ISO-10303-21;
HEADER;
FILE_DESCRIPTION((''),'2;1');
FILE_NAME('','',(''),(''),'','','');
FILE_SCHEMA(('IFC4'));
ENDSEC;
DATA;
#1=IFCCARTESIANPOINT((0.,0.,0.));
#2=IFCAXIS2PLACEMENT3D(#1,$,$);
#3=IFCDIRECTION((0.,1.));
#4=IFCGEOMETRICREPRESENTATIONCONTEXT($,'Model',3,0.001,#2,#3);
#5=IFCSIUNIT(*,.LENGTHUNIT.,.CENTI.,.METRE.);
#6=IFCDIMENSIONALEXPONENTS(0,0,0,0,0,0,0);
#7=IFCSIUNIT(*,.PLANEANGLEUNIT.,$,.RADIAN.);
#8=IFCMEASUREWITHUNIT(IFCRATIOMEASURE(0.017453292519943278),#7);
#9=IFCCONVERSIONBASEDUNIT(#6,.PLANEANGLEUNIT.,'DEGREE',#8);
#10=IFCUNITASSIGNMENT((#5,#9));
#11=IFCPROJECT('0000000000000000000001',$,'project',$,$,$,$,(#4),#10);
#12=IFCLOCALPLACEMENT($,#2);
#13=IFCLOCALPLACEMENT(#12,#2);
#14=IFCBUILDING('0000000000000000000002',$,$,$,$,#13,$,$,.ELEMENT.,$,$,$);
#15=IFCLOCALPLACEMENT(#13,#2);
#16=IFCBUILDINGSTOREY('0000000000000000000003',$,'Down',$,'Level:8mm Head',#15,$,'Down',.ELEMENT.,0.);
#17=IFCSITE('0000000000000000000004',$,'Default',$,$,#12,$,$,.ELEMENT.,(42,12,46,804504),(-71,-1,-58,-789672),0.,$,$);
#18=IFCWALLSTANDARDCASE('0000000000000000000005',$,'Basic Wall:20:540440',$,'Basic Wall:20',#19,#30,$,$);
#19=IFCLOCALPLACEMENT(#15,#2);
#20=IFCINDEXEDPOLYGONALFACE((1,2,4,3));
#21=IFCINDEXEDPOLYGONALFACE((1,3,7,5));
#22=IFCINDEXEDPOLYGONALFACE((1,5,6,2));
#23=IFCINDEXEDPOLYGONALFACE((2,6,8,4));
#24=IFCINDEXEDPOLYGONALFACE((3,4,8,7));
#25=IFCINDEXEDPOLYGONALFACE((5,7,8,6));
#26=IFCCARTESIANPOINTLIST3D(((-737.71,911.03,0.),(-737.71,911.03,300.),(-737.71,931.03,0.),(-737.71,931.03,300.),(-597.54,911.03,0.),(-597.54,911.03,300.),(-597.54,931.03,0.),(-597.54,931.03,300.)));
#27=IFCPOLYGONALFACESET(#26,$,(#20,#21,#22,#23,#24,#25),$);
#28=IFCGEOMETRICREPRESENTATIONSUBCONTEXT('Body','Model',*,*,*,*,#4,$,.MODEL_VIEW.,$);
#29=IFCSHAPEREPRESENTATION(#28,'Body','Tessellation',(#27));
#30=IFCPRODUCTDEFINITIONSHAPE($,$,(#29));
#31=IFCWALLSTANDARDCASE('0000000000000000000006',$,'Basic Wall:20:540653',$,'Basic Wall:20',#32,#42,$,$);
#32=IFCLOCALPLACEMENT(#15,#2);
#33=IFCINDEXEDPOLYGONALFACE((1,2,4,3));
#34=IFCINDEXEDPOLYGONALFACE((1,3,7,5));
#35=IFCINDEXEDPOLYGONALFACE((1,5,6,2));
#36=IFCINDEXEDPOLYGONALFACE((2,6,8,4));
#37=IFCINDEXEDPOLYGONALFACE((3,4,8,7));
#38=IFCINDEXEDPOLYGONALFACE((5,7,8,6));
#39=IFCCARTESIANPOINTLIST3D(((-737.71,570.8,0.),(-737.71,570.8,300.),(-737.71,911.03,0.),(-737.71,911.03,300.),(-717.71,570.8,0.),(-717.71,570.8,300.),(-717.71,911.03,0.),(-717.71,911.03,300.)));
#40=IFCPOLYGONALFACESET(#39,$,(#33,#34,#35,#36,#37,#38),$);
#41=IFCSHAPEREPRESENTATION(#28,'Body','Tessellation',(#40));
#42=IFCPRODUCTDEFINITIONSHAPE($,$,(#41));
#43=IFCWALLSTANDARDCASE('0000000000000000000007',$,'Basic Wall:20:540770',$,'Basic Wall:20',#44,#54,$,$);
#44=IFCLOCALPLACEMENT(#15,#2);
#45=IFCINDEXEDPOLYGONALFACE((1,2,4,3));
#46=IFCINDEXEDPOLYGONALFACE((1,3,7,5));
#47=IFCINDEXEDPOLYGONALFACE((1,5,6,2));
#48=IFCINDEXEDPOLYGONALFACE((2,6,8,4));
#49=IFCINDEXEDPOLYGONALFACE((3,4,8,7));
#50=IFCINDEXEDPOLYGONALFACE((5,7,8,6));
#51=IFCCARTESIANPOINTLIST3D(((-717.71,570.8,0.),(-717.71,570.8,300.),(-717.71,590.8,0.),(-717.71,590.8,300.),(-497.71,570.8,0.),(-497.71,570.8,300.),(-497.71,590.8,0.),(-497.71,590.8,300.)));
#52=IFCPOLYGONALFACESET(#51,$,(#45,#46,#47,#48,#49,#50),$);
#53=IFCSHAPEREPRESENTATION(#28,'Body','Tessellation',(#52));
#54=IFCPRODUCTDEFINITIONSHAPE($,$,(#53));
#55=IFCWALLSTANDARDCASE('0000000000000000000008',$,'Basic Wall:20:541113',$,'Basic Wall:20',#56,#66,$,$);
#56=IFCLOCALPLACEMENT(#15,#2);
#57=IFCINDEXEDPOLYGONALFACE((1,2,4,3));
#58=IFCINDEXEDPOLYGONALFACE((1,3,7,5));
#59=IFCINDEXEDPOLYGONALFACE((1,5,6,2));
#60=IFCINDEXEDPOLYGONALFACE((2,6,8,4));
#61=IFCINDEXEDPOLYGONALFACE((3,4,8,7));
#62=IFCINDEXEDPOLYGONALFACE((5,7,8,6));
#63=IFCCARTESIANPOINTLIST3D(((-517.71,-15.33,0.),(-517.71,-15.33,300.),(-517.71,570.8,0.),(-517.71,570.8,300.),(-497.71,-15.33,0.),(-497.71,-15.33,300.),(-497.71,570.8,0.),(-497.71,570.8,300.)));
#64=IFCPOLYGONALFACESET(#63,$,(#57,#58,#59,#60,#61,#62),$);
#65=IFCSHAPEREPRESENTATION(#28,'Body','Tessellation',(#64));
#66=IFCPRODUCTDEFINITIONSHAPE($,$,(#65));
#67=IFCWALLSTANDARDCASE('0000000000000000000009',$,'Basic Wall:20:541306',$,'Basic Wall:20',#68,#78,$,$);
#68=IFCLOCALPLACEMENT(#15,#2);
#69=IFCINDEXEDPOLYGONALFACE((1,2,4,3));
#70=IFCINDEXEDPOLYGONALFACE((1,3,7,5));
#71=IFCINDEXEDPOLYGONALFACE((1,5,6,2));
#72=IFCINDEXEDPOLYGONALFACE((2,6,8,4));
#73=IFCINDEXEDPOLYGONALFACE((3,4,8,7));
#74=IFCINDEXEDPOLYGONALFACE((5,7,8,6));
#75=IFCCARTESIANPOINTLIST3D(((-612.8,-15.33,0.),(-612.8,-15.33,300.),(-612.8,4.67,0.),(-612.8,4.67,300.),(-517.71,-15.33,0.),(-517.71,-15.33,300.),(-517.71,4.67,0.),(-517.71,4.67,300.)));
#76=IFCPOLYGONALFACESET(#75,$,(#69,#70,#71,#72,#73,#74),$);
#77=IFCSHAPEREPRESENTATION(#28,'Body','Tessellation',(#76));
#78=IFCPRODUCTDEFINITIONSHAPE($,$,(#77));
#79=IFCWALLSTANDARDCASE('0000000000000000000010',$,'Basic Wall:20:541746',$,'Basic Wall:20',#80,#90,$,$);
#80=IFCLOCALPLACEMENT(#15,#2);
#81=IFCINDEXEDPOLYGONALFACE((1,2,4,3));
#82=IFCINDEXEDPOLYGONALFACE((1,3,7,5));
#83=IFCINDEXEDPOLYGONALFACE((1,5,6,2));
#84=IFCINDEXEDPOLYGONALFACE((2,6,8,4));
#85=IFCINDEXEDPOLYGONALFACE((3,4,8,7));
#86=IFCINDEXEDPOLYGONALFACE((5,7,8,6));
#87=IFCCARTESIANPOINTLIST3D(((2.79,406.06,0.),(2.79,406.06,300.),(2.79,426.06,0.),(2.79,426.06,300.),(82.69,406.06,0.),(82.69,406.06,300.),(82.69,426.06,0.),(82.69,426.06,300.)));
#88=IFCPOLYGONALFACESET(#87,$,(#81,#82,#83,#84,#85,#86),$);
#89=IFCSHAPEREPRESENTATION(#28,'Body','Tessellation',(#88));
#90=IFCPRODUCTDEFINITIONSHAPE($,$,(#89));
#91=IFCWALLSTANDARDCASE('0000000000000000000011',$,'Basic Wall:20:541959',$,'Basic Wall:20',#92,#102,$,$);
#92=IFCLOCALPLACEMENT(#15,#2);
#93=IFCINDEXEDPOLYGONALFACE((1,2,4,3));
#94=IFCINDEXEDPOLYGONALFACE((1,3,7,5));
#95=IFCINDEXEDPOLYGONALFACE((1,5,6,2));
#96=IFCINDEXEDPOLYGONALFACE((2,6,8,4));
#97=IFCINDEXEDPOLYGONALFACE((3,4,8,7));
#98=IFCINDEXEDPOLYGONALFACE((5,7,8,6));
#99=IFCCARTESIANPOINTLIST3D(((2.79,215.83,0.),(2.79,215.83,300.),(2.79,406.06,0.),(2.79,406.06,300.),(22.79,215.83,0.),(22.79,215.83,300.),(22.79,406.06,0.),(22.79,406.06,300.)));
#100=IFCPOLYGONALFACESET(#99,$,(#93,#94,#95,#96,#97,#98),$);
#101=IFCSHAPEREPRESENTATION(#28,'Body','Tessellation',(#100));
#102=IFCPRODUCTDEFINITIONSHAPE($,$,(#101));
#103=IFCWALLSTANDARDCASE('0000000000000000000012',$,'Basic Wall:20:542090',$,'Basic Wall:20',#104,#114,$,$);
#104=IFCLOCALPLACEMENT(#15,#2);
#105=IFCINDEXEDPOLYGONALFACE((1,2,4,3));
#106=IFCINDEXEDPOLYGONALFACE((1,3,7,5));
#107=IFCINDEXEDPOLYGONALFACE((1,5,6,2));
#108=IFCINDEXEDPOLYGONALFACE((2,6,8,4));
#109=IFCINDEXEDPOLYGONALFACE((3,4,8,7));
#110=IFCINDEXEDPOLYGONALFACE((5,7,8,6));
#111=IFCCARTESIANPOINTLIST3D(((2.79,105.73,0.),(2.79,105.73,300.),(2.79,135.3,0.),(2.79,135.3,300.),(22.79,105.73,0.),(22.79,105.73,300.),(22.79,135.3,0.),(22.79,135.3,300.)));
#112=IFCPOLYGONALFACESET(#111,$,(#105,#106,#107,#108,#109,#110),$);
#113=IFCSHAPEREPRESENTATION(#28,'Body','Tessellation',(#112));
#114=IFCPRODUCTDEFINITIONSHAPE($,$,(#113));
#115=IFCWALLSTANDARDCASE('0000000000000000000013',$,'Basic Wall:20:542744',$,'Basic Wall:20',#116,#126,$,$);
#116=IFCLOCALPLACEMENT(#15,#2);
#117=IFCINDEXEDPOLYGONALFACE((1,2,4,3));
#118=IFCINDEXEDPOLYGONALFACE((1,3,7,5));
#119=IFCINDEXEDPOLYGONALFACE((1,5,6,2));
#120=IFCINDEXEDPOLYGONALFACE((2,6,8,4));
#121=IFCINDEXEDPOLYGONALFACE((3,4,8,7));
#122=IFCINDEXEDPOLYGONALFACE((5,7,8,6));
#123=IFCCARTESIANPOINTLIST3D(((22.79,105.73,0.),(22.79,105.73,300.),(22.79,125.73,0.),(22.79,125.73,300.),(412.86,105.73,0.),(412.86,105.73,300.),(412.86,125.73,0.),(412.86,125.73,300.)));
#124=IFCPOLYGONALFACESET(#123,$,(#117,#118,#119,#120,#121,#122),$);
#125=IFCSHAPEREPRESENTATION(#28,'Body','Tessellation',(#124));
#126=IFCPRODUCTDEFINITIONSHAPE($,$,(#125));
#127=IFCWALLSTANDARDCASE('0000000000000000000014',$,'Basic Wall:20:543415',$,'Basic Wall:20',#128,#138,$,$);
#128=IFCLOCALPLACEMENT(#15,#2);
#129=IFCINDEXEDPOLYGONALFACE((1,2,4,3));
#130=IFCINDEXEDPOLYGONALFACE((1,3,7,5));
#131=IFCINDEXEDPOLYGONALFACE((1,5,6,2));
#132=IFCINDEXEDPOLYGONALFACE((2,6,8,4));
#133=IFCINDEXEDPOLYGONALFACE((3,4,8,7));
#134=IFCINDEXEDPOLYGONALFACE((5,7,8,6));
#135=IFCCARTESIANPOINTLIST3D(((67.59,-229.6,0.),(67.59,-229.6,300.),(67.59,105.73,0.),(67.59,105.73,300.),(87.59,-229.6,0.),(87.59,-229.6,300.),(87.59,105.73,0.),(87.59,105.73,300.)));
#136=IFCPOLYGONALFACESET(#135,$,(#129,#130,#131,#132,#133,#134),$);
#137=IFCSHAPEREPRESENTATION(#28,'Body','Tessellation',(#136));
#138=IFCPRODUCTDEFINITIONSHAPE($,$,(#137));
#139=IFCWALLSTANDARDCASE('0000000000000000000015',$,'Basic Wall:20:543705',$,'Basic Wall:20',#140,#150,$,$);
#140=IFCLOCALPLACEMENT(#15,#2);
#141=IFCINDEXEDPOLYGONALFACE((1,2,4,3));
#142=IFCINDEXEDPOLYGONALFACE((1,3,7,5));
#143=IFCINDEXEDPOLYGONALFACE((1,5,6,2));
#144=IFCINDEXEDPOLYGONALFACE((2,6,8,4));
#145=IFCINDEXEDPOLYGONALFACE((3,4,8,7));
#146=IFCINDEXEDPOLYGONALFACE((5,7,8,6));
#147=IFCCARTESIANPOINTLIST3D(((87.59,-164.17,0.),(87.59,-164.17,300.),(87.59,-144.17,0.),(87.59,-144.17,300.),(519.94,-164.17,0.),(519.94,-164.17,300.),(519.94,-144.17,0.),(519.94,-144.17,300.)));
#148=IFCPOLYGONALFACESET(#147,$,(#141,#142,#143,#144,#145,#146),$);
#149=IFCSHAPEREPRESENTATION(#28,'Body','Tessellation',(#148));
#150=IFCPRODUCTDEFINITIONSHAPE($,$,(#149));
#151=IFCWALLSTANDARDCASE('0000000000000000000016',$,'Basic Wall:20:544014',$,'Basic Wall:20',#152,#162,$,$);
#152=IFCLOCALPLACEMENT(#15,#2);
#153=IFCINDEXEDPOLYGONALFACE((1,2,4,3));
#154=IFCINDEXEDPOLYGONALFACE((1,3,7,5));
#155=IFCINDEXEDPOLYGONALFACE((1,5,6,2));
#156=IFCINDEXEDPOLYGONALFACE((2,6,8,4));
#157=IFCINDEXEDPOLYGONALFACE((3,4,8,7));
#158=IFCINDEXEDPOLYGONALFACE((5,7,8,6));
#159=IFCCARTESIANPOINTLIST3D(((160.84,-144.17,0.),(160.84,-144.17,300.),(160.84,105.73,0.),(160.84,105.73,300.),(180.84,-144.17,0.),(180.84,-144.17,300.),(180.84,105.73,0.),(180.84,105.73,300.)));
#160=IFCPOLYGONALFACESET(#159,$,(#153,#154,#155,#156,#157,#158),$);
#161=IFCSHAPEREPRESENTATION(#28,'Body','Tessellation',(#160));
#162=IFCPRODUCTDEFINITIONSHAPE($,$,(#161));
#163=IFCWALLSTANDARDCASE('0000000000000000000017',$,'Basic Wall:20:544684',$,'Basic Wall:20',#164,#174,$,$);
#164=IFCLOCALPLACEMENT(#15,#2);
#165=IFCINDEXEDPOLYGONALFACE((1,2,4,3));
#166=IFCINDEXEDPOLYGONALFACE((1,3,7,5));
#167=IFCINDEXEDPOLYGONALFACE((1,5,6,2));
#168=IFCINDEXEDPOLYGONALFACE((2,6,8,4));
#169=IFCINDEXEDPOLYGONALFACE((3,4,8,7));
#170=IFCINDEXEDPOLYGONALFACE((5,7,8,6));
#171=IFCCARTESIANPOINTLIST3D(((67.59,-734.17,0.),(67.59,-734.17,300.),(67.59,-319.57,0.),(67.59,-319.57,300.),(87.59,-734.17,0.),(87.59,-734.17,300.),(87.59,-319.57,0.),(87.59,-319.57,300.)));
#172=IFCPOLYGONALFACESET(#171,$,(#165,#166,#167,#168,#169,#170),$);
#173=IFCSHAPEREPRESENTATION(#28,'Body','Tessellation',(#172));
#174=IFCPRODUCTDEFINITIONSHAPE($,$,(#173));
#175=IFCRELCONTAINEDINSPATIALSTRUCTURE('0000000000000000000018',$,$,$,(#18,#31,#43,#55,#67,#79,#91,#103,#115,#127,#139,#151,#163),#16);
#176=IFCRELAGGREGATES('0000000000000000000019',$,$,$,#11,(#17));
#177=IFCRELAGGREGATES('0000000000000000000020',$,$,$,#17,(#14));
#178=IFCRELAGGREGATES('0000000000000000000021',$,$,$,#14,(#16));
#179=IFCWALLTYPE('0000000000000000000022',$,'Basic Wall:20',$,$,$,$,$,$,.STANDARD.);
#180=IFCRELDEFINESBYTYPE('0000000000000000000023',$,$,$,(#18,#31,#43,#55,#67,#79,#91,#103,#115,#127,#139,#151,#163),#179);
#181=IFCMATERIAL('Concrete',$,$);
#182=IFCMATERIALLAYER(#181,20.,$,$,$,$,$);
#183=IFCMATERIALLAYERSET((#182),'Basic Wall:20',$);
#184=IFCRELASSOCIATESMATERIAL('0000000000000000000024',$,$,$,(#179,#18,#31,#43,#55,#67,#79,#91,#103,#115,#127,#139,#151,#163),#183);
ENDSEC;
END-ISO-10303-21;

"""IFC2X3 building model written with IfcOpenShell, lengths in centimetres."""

from ifc_helpers import new_model, entity, si_unit, converted_unit, direction, frame, frame_2d, origin, place, context, subcontext, project, spatial, rectangle, extrude, material, layer, layer_set, layer_usage, type_object, element, save


model = new_model("IFC2X3")

# Units and contexts
model_context = context("Model", 3, precision=0.001, world=origin(), true_north=direction((0.0, 1.0)))
body_context = subcontext(model_context, "Body", "Model", "MODEL_VIEW")
ifc_project = project(units=[si_unit("LENGTHUNIT", "METRE", prefix="CENTI"), converted_unit("PLANEANGLEUNIT", "DEGREE", entity("IfcRatioMeasure", 0.017453292519943278), si_unit("PLANEANGLEUNIT", "RADIAN"), dimensions=[0, 0, 0, 0, 0, 0, 0])], contexts=[model_context])

# Site, building, storey
site_placement = place(None, origin())
site = spatial("IfcSite", under=ifc_project, at=site_placement, Name="Default", CompositionType="ELEMENT", RefLatitude=(42, 12, 46, 804504), RefLongitude=(-71, -1, -58, -789672), RefElevation=0.0)
building_placement = place(site_placement, origin())
building = spatial("IfcBuilding", under=site, at=building_placement, CompositionType="ELEMENT")
storey_placement = place(building_placement, origin())
storey = spatial("IfcBuildingStorey", under=building, at=storey_placement, Name="Down", ObjectType="Level:8mm Head", LongName="Down", CompositionType="ELEMENT", Elevation=0.0)

# Shared definitions
ifc_material = material(Name="Concrete")

# Walls
ifc_layer_1 = layer(ifc_material, 20.0)
ifc_layer_set_1 = layer_set([ifc_layer_1], Name="Basic Wall:20")
wall_type_1 = type_object("IfcWallType", Name="Basic Wall:20", PredefinedType="STANDARD", material=ifc_layer_set_1)
ifc_layer_usage_1 = layer_usage(ifc_layer_set_1, "AXIS2", "NEGATIVE", 10.0)
wall_1_placement = place(storey_placement, frame((-597.54, 921.03, 0.0), z_axis=(0.0, 0.0, 1.0), x_axis=(-1.0, 0.0, 0.0)))
element("IfcWallStandardCase", 1, at=wall_1_placement, inside=storey, type_object=wall_type_1, material=ifc_layer_usage_1, Name="Basic Wall:20:540440", ObjectType="Basic Wall:20", context=body_context, shape_type="SweptSolid", body=[
    extrude(rectangle(XDim=140.17, YDim=20.0, at=frame_2d((70.08, 0.0), x_axis=(-1.0, 0.0))), origin(), (0.0, 0.0, 1.0), 300.0),
])
ifc_layer_usage_2 = layer_usage(ifc_layer_set_1, "AXIS2", "POSITIVE", -10.0)
wall_2_placement = place(storey_placement, frame((-727.71, 911.03, 0.0), z_axis=(0.0, 0.0, 1.0), x_axis=(0.0, -1.0, 0.0)))
element("IfcWallStandardCase", 2, at=wall_2_placement, inside=storey, type_object=wall_type_1, material=ifc_layer_usage_2, Name="Basic Wall:20:540653", ObjectType="Basic Wall:20", context=body_context, shape_type="SweptSolid", body=[
    extrude(rectangle(XDim=340.23, YDim=20.0, at=frame_2d((170.12, 0.0), x_axis=(-1.0, 0.0))), origin(), (0.0, 0.0, 1.0), 300.0),
])
ifc_layer_usage_3 = layer_usage(ifc_layer_set_1, "AXIS2", "POSITIVE", -10.0)
wall_3_placement = place(storey_placement, frame((-717.71, 580.8, 0.0)))
element("IfcWallStandardCase", 3, at=wall_3_placement, inside=storey, type_object=wall_type_1, material=ifc_layer_usage_3, Name="Basic Wall:20:540770", ObjectType="Basic Wall:20", context=body_context, shape_type="SweptSolid", body=[
    extrude(rectangle(XDim=220.0, YDim=20.0, at=frame_2d((110.0, 0.0), x_axis=(-1.0, 0.0))), origin(), (0.0, 0.0, 1.0), 300.0),
])
ifc_layer_usage_4 = layer_usage(ifc_layer_set_1, "AXIS2", "NEGATIVE", 10.0)
wall_4_placement = place(storey_placement, frame((-507.71, 570.8, 0.0), z_axis=(0.0, 0.0, 1.0), x_axis=(0.0, -1.0, 0.0)))
element("IfcWallStandardCase", 4, at=wall_4_placement, inside=storey, type_object=wall_type_1, material=ifc_layer_usage_4, Name="Basic Wall:20:541113", ObjectType="Basic Wall:20", context=body_context, shape_type="SweptSolid", body=[
    extrude(rectangle(XDim=586.13, YDim=20.0, at=frame_2d((293.07, 0.0), x_axis=(-1.0, 0.0))), origin(), (0.0, 0.0, 1.0), 300.0),
])
ifc_layer_usage_5 = layer_usage(ifc_layer_set_1, "AXIS2", "NEGATIVE", 10.0)
wall_5_placement = place(storey_placement, frame((-517.71, -5.33, 0.0), z_axis=(0.0, 0.0, 1.0), x_axis=(-1.0, 0.0, 0.0)))
element("IfcWallStandardCase", 5, at=wall_5_placement, inside=storey, type_object=wall_type_1, material=ifc_layer_usage_5, Name="Basic Wall:20:541306", ObjectType="Basic Wall:20", context=body_context, shape_type="SweptSolid", body=[
    extrude(rectangle(XDim=95.09, YDim=20.0, at=frame_2d((47.54, 0.0), x_axis=(-1.0, 0.0))), origin(), (0.0, 0.0, 1.0), 300.0),
])
ifc_layer_usage_6 = layer_usage(ifc_layer_set_1, "AXIS2", "NEGATIVE", 10.0)
wall_6_placement = place(storey_placement, frame((82.69, 416.06, 0.0), z_axis=(0.0, 0.0, 1.0), x_axis=(-1.0, 0.0, 0.0)))
element("IfcWallStandardCase", 6, at=wall_6_placement, inside=storey, type_object=wall_type_1, material=ifc_layer_usage_6, Name="Basic Wall:20:541746", ObjectType="Basic Wall:20", context=body_context, shape_type="SweptSolid", body=[
    extrude(rectangle(XDim=79.9, YDim=20.0, at=frame_2d((39.95, 0.0), x_axis=(-1.0, 0.0))), origin(), (0.0, 0.0, 1.0), 300.0),
])
ifc_layer_usage_7 = layer_usage(ifc_layer_set_1, "AXIS2", "POSITIVE", -10.0)
wall_7_placement = place(storey_placement, frame((12.79, 406.06, 0.0), z_axis=(0.0, 0.0, 1.0), x_axis=(0.0, -1.0, 0.0)))
element("IfcWallStandardCase", 7, at=wall_7_placement, inside=storey, type_object=wall_type_1, material=ifc_layer_usage_7, Name="Basic Wall:20:541959", ObjectType="Basic Wall:20", context=body_context, shape_type="SweptSolid", body=[
    extrude(rectangle(XDim=190.23, YDim=20.0, at=frame_2d((95.12, 0.0), x_axis=(-1.0, 0.0))), origin(), (0.0, 0.0, 1.0), 300.0),
])
ifc_layer_usage_8 = layer_usage(ifc_layer_set_1, "AXIS2", "POSITIVE", -10.0)
wall_8_placement = place(storey_placement, frame((12.79, 135.3, 0.0), z_axis=(0.0, 0.0, 1.0), x_axis=(0.0, -1.0, 0.0)))
element("IfcWallStandardCase", 8, at=wall_8_placement, inside=storey, type_object=wall_type_1, material=ifc_layer_usage_8, Name="Basic Wall:20:542090", ObjectType="Basic Wall:20", context=body_context, shape_type="SweptSolid", body=[
    extrude(rectangle(XDim=29.57, YDim=20.0, at=frame_2d((14.78, 0.0), x_axis=(-1.0, 0.0))), origin(), (0.0, 0.0, 1.0), 300.0),
])
ifc_layer_usage_9 = layer_usage(ifc_layer_set_1, "AXIS2", "POSITIVE", -10.0)
wall_9_placement = place(storey_placement, frame((22.79, 115.73, 0.0)))
element("IfcWallStandardCase", 9, at=wall_9_placement, inside=storey, type_object=wall_type_1, material=ifc_layer_usage_9, Name="Basic Wall:20:542744", ObjectType="Basic Wall:20", context=body_context, shape_type="SweptSolid", body=[
    extrude(rectangle(XDim=390.07, YDim=20.0, at=frame_2d((195.03, 0.0), x_axis=(-1.0, 0.0))), origin(), (0.0, 0.0, 1.0), 300.0),
])
ifc_layer_usage_10 = layer_usage(ifc_layer_set_1, "AXIS2", "POSITIVE", -10.0)
wall_10_placement = place(storey_placement, frame((77.59, 105.73, 0.0), z_axis=(0.0, 0.0, 1.0), x_axis=(0.0, -1.0, 0.0)))
element("IfcWallStandardCase", 10, at=wall_10_placement, inside=storey, type_object=wall_type_1, material=ifc_layer_usage_10, Name="Basic Wall:20:543415", ObjectType="Basic Wall:20", context=body_context, shape_type="SweptSolid", body=[
    extrude(rectangle(XDim=335.33, YDim=20.0, at=frame_2d((167.67, 0.0), x_axis=(-1.0, 0.0))), origin(), (0.0, 0.0, 1.0), 300.0),
])
ifc_layer_usage_11 = layer_usage(ifc_layer_set_1, "AXIS2", "POSITIVE", -10.0)
wall_11_placement = place(storey_placement, frame((87.59, -154.17, 0.0)))
element("IfcWallStandardCase", 11, at=wall_11_placement, inside=storey, type_object=wall_type_1, material=ifc_layer_usage_11, Name="Basic Wall:20:543705", ObjectType="Basic Wall:20", context=body_context, shape_type="SweptSolid", body=[
    extrude(rectangle(XDim=432.35, YDim=20.0, at=frame_2d((216.18, 0.0), x_axis=(-1.0, 0.0))), origin(), (0.0, 0.0, 1.0), 300.0),
])
ifc_layer_usage_12 = layer_usage(ifc_layer_set_1, "AXIS2", "POSITIVE", -10.0)
wall_12_placement = place(storey_placement, frame((170.84, -144.17, 0.0), z_axis=(0.0, 0.0, 1.0), x_axis=(0.0, 1.0, 0.0)))
element("IfcWallStandardCase", 12, at=wall_12_placement, inside=storey, type_object=wall_type_1, material=ifc_layer_usage_12, Name="Basic Wall:20:544014", ObjectType="Basic Wall:20", context=body_context, shape_type="SweptSolid", body=[
    extrude(rectangle(XDim=249.9, YDim=20.0, at=frame_2d((124.95, 0.0), x_axis=(-1.0, 0.0))), origin(), (0.0, 0.0, 1.0), 300.0),
])
ifc_layer_usage_13 = layer_usage(ifc_layer_set_1, "AXIS2", "NEGATIVE", 10.0)
wall_13_placement = place(storey_placement, frame((77.59, -319.57, 0.0), z_axis=(0.0, 0.0, 1.0), x_axis=(0.0, -1.0, 0.0)))
element("IfcWallStandardCase", 13, at=wall_13_placement, inside=storey, type_object=wall_type_1, material=ifc_layer_usage_13, Name="Basic Wall:20:544684", ObjectType="Basic Wall:20", context=body_context, shape_type="SweptSolid", body=[
    extrude(rectangle(XDim=414.6, YDim=20.0, at=frame_2d((207.3, 0.0), x_axis=(-1.0, 0.0))), origin(), (0.0, 0.0, 1.0), 300.0),
])

save(model, "model.ifc")
